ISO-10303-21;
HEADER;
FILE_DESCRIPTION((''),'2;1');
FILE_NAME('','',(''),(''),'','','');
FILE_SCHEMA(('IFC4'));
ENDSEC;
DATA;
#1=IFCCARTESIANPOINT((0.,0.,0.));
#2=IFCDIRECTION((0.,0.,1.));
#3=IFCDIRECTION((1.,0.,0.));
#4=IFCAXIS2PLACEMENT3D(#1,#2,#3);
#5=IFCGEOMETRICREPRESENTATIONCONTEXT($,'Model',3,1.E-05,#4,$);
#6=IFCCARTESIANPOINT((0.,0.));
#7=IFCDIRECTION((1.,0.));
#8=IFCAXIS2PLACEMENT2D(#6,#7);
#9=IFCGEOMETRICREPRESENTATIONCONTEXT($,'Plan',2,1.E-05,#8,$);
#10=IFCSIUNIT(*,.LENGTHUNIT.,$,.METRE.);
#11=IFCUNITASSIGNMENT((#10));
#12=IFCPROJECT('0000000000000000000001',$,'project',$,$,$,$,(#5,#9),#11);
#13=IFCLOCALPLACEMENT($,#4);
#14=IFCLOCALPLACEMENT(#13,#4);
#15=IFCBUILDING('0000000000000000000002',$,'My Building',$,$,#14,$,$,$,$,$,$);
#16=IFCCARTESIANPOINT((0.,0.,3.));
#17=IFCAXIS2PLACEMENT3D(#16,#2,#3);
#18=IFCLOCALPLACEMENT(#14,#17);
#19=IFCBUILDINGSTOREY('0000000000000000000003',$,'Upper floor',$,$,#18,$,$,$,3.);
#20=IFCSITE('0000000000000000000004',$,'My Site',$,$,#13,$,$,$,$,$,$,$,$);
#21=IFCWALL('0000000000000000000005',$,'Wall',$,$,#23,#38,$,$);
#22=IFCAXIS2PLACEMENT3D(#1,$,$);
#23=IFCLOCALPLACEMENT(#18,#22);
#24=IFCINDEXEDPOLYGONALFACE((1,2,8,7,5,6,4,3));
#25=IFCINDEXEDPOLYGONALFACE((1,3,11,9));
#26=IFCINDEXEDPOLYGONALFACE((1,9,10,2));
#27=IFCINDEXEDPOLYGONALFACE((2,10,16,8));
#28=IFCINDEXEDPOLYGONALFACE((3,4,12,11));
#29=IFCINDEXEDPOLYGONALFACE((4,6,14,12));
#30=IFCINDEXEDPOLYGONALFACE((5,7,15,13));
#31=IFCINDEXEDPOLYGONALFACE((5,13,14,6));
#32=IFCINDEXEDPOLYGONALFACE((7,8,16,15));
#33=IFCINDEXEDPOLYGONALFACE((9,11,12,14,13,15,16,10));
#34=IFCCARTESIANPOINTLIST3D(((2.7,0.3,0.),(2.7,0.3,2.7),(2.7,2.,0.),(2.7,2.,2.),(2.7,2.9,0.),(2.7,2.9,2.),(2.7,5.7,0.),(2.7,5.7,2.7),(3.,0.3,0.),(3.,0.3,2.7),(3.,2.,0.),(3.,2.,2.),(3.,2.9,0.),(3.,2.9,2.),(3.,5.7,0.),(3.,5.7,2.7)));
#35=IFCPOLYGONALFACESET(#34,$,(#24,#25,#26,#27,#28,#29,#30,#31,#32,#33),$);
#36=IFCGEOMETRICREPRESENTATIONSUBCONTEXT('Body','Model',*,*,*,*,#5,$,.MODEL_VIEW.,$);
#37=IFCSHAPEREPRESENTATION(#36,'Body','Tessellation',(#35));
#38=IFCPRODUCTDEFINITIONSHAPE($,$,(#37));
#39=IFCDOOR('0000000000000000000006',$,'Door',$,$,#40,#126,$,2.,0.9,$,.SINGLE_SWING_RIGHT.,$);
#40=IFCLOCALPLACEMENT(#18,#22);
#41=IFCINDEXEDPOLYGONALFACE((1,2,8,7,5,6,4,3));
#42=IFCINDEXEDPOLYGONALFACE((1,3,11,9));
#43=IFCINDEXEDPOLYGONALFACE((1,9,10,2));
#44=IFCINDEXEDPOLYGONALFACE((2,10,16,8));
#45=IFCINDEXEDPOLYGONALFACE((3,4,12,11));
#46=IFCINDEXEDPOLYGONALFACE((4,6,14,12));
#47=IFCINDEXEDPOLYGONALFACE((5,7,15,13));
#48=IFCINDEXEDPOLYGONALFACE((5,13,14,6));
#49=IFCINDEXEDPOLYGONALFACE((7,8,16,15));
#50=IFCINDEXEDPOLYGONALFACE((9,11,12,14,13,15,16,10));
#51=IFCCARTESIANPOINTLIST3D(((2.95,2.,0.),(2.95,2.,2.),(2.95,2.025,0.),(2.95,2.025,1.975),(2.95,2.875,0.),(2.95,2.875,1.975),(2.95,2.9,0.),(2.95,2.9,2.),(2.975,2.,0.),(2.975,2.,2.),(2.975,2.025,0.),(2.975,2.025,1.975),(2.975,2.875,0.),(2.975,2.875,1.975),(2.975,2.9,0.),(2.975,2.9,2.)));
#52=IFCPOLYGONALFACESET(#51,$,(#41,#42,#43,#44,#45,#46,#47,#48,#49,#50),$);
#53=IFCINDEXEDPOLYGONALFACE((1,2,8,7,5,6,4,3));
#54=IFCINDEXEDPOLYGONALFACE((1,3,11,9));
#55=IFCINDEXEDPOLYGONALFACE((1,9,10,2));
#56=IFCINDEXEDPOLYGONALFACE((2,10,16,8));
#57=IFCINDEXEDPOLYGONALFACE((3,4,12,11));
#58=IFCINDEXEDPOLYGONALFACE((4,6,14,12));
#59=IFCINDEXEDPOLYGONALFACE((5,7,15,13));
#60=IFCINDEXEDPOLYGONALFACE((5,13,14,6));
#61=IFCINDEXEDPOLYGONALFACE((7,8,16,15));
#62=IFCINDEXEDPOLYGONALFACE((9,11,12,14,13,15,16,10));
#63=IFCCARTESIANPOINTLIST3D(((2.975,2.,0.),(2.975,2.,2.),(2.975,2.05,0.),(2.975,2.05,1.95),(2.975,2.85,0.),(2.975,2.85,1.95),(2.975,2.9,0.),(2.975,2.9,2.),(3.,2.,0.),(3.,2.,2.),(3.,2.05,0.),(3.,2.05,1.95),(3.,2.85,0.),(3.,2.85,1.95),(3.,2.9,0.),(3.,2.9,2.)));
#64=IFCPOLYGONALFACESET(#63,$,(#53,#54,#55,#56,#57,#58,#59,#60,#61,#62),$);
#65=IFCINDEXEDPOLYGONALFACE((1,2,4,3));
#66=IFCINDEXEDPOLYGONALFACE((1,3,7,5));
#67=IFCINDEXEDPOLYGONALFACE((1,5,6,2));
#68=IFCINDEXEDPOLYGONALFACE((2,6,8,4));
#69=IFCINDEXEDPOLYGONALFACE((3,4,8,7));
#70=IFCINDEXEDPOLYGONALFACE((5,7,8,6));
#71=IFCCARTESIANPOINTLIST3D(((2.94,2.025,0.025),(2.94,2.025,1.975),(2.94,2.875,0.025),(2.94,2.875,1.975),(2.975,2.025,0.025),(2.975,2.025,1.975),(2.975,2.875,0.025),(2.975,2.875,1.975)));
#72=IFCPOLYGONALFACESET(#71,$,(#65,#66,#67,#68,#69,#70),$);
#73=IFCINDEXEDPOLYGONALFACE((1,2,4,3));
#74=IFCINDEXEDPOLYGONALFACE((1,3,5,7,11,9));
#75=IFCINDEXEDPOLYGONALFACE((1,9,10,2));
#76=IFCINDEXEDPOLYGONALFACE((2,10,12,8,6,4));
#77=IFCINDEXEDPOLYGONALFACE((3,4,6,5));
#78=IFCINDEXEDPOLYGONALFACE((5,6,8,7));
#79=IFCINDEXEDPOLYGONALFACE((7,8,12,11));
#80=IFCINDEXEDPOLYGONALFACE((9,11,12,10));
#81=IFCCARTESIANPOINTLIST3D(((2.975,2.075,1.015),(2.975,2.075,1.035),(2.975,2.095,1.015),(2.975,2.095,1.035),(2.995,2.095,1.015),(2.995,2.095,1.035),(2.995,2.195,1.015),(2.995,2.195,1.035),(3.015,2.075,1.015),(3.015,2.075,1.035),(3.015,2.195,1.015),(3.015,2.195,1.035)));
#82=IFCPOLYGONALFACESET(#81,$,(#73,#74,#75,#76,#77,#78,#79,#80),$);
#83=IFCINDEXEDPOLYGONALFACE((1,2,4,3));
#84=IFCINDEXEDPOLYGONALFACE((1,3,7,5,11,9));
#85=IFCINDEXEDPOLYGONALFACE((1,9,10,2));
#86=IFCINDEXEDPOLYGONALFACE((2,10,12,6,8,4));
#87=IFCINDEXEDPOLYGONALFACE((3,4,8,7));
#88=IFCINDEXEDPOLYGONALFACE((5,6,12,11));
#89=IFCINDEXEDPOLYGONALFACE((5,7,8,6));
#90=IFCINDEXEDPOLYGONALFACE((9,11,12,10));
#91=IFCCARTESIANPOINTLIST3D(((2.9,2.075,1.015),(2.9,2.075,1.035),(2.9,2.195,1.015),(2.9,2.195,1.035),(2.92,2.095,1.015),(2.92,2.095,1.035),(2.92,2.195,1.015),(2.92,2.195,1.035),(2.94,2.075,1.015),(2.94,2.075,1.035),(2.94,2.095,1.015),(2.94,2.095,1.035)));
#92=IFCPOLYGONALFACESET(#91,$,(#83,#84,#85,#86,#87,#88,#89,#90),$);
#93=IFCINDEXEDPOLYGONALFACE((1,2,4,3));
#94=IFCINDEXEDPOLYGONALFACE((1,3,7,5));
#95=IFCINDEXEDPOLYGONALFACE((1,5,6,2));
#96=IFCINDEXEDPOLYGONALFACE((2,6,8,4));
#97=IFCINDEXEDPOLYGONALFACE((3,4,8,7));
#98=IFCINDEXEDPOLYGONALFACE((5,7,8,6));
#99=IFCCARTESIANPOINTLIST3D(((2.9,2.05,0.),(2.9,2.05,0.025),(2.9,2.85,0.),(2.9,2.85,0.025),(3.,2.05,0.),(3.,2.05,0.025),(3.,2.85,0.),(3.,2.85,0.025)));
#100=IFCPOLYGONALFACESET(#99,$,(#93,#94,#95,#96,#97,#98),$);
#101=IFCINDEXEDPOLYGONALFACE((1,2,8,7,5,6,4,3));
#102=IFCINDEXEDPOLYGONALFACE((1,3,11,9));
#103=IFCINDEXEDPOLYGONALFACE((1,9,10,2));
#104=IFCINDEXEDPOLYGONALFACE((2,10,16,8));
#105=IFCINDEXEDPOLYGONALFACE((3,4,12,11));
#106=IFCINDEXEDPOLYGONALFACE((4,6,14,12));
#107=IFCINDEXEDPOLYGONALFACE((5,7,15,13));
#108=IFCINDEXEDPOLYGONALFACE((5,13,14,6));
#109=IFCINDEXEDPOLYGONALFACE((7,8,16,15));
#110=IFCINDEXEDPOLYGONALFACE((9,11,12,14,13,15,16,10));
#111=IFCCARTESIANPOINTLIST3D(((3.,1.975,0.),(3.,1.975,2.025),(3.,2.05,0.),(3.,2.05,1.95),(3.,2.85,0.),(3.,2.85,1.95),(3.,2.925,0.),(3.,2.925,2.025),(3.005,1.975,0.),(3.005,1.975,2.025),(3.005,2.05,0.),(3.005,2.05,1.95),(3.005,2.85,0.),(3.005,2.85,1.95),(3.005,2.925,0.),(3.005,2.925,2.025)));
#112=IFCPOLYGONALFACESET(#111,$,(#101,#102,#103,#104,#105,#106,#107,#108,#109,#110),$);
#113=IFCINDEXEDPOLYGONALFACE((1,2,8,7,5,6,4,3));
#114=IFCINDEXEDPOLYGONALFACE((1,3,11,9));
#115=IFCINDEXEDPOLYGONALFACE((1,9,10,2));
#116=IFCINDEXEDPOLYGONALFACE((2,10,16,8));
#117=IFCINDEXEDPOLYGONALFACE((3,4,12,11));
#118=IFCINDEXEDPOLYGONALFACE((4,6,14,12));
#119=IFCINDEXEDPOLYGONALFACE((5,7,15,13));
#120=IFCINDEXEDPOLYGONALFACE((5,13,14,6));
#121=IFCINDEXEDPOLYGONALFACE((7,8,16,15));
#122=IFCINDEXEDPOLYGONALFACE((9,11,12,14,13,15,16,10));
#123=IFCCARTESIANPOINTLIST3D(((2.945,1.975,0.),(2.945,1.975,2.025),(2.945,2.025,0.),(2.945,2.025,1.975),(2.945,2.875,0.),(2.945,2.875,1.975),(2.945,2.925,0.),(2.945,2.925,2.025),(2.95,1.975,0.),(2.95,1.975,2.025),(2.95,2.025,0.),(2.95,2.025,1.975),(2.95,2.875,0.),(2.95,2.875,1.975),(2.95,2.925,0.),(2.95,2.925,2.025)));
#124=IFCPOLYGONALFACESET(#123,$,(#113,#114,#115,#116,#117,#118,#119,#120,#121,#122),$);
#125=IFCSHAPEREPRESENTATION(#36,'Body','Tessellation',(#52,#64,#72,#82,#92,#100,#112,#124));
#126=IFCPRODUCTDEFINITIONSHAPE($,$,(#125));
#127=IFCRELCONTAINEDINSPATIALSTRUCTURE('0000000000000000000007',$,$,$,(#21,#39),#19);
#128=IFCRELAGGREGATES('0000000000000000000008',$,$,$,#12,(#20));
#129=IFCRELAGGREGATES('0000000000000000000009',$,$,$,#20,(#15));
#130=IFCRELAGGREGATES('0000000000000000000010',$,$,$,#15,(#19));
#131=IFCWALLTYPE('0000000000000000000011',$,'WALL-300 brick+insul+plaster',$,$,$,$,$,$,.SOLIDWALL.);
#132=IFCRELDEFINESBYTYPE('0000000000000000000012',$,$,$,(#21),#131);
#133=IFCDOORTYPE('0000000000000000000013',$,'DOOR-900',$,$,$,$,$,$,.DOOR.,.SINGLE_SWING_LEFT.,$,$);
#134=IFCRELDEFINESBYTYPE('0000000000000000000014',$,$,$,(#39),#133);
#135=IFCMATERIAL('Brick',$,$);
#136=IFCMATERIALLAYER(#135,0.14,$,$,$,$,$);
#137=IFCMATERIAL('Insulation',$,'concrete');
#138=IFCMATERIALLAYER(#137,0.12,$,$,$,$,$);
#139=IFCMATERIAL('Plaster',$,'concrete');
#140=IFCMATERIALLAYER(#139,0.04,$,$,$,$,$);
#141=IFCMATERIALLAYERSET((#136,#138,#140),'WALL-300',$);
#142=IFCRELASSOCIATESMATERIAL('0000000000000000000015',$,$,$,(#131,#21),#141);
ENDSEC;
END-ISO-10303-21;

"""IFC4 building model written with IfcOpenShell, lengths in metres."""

from ifc_helpers import new_model, entity, si_unit, frame, origin_with_axes, origin_2d_with_axis, place, context, subcontext, project, spatial, line, indexed_curve, outline, extrude, shape, source, transform, mapped, material, layer, layer_set, layer_usage, type_object, type_shapes, element, fill, save


model = new_model("IFC4")

# Units and contexts
model_context = context("Model", 3, precision=1e-05, world=origin_with_axes())
plan_context = context("Plan", 2, precision=1e-05, world=origin_2d_with_axis())
body_context_1 = subcontext(model_context, "Body", "Model", "MODEL_VIEW")
body_context_2 = subcontext(plan_context, "Body", "Plan", "PLAN_VIEW")
ifc_project = project(units=[si_unit("LENGTHUNIT", "METRE")], contexts=[model_context, plan_context])

# Site, building, storey
site_placement = place(None, origin_with_axes())
site = spatial("IfcSite", under=ifc_project, at=site_placement, Name="My Site")
building_placement = place(site_placement, origin_with_axes())
building = spatial("IfcBuilding", under=site, at=building_placement, Name="My Building")
storey_placement = place(building_placement, frame((0.0, 0.0, 3.0), z_axis=(0.0, 0.0, 1.0), x_axis=(1.0, 0.0, 0.0)))
storey = spatial("IfcBuildingStorey", under=building, at=storey_placement, Name="Upper floor", Elevation=3.0)

# Shared definitions
ifc_material_1 = material(Name="Brick")

# Shared definitions
ifc_layer_1 = layer(ifc_material_1, 0.14)
ifc_material_2 = material(Name="Insulation", Category="concrete")
ifc_layer_2 = layer(ifc_material_2, 0.12)
ifc_material_3 = material(Name="Plaster", Category="concrete")
ifc_layer_3 = layer(ifc_material_3, 0.04)
ifc_layer_set_1 = layer_set([ifc_layer_1, ifc_layer_2, ifc_layer_3], Name="WALL-300")
wall_type = type_object("IfcWallType", Name="WALL-300 brick+insul+plaster", PredefinedType="SOLIDWALL", material=ifc_layer_set_1)

# Wall, opening, door
ifc_layer_usage_1 = layer_usage(ifc_layer_set_1, "AXIS2", "POSITIVE", 0.0)
wall_1_placement = place(storey_placement, frame((3.0, 0.0, 0.0), z_axis=(0.0, 0.0, 1.0), x_axis=(0.0, 1.0, 0.0)))
wall_1 = element("IfcWall", 1, at=wall_1_placement, inside=storey, type_object=wall_type, material=ifc_layer_usage_1, Name="Wall", context=body_context_1, shape_type="SweptSolid", body=[
    extrude(outline(indexed_curve([(0.3, 0.0), (0.3, 0.3), (5.7, 0.3), (5.7, 0.0)], segments=[line(1, 2, 3, 4, 1)])), origin_with_axes(), (0.0, 0.0, 1.0), 2.7),
])
shared_shape_1 = source(origin_with_axes(), body_context_1, "Body", "SweptSolid", [
    extrude(outline(indexed_curve([(0.0, 0.0), (0.9, 0.0), (0.9, 2.0), (0.0, 2.0)], segments=[line(1, 2, 3, 4, 1)])), frame((0.0, -0.6, 0.0), z_axis=(0.0, -1.0, 0.0), x_axis=(1.0, 0.0, 0.0)), (0.0, 0.0, -1.0), 1.2),
])
opening_1_placement = place(wall_1_placement, frame((2.0, 0.0, 0.0), z_axis=(0.0, 0.0, 1.0), x_axis=(1.0, 0.0, 0.0)))
opening_1 = element("IfcOpeningElement", 2, at=opening_1_placement, cuts=wall_1, PredefinedType="OPENING", context=body_context_1, shape_type="MappedRepresentation", body=[
    mapped(shared_shape_1, transform((0.0, 0.0, 0.0), x_axis=(1.0, 0.0, 0.0), y_axis=(0.0, 1.0, 0.0), z_axis=(0.0, 0.0, 1.0), scale=1.0)),
])
door_type = type_object("IfcDoorType", Name="DOOR-900", OperationType="SINGLE_SWING_LEFT", PredefinedType="DOOR")
shared_shape_2 = source(origin_with_axes(), body_context_1, "Body", "SweptSolid", [
    extrude(outline(indexed_curve([(0.0, 0.0), (0.0, 2.0), (0.9, 2.0), (0.9, 0.0), (0.875, 0.0), (0.875, 1.975), (0.025, 1.975), (0.025, 0.0)], segments=[line(1, 2, 3, 4, 5, 6, 7, 8, 1)])), frame((0.0, 0.025, 0.0), z_axis=(0.0, -1.0, 0.0), x_axis=(1.0, 0.0, 0.0)), (0.0, 0.0, -1.0), 0.025),
    extrude(outline(indexed_curve([(0.0, 0.0), (0.0, 2.0), (0.9, 2.0), (0.9, 0.0), (0.85, 0.0), (0.85, 1.95), (0.05, 1.95), (0.05, 0.0)], segments=[line(1, 2, 3, 4, 5, 6, 7, 8, 1)])), frame((0.0, 0.0, 0.0), z_axis=(0.0, -1.0, 0.0), x_axis=(1.0, 0.0, 0.0)), (0.0, 0.0, -1.0), 0.025),
    extrude(outline(indexed_curve([(0.0, 0.0), (0.85, 0.0), (0.85, 0.035), (0.0, 0.035)], segments=[line(1, 2, 3, 4, 1)])), frame((0.025, 0.025, 0.025), z_axis=(0.0, 0.0, 1.0), x_axis=(1.0, 0.0, 0.0)), (0.0, 0.0, 1.0), 1.95),
    extrude(outline(indexed_curve([(0.0, 0.0), (0.0, -0.04), (0.12, -0.04), (0.12, -0.02), (0.02, -0.02), (0.02, 0.0)], segments=[line(1, 2, 3, 4, 5, 6, 1)])), frame((0.075, 0.025, 1.015), z_axis=(0.0, 0.0, 1.0), x_axis=(1.0, 0.0, 0.0)), (0.0, 0.0, 1.0), 0.02),
    extrude(outline(indexed_curve([(0.0, 0.0), (0.0, 0.04), (0.12, 0.04), (0.12, 0.02), (0.02, 0.02), (0.02, 0.0)], segments=[line(1, 2, 3, 4, 5, 6, 1)])), frame((0.075, 0.06, 1.015), z_axis=(0.0, 0.0, 1.0), x_axis=(1.0, 0.0, 0.0)), (0.0, 0.0, 1.0), 0.02),
    extrude(outline(indexed_curve([(0.0, 0.0), (0.8, 0.0), (0.8, 0.1), (0.0, 0.1)], segments=[line(1, 2, 3, 4, 1)])), frame((0.05, 0.0, 0.0), z_axis=(0.0, 0.0, 1.0), x_axis=(1.0, 0.0, 0.0)), (0.0, 0.0, 1.0), 0.025),
    extrude(outline(indexed_curve([(0.0, 0.0), (0.0, 2.025), (0.95, 2.025), (0.95, 0.0), (0.875, 0.0), (0.875, 1.95), (0.075, 1.95), (0.075, 0.0)], segments=[line(1, 2, 3, 4, 5, 6, 7, 8, 1)])), frame((-0.025, -0.005, 0.0), z_axis=(0.0, -1.0, 0.0), x_axis=(1.0, 0.0, 0.0)), (0.0, 0.0, -1.0), 0.005),
    extrude(outline(indexed_curve([(0.0, 0.0), (0.0, 2.025), (0.95, 2.025), (0.95, 0.0), (0.9, 0.0), (0.9, 1.975), (0.05, 1.975), (0.05, 0.0)], segments=[line(1, 2, 3, 4, 5, 6, 7, 8, 1)])), frame((-0.025, 0.05, 0.0), z_axis=(0.0, -1.0, 0.0), x_axis=(1.0, 0.0, 0.0)), (0.0, 0.0, -1.0), 0.005),
])
shared_shape_3 = source(origin_with_axes(), body_context_2, "Body", "Curve2D", [
    entity("IfcIndexedPolyCurve", entity("IfcCartesianPointList2D", [[0.0, 0.0], [0.0, 0.05], [0.025, 0.05], [0.025, 0.025], [0.05, 0.025], [0.05, 0.0]]), [entity("IfcLineIndex", [1, 2, 3, 4, 5, 6, 1])]),
    entity("IfcIndexedPolyCurve", entity("IfcCartesianPointList2D", [[0.9, 0.0], [0.9, 0.05], [0.875, 0.05], [0.875, 0.025], [0.85, 0.025], [0.85, 0.0]]), [entity("IfcLineIndex", [1, 2, 3, 4, 5, 6, 1])]),
    entity("IfcTrimmedCurve", entity("IfcEllipse", entity("IfcAxis2Placement2D", entity("IfcCartesianPoint", [0.84, 0.05]), entity("IfcDirection", [1.0, 0.0])), 0.815, 0.85), [entity("IfcCartesianPoint", [0.84, 0.9])], [entity("IfcCartesianPoint", [0.025, 0.05])], True, "CARTESIAN"),
    entity("IfcIndexedPolyCurve", entity("IfcCartesianPointList2D", [[0.875, 0.05], [0.84, 0.05], [0.84, 0.9], [0.875, 0.9]]), [entity("IfcLineIndex", [1, 2, 3, 4, 1])]),
])
type_shapes(door_type, [shared_shape_2, shared_shape_3])
door_placement = place(opening_1_placement, frame((0.0, 0.0, 0.0), z_axis=(0.0, 0.0, 1.0), x_axis=(1.0, 0.0, 0.0)))
door = element("IfcDoor", 3, at=door_placement, inside=storey, type_object=door_type, Name="Door", OperationType="SINGLE_SWING_RIGHT", OverallHeight=2.0, OverallWidth=0.9, shapes=[
    shape(body_context_1, "Body", "MappedRepresentation", [mapped(shared_shape_2, transform((0.0, 0.0, 0.0), x_axis=(1.0, 0.0, 0.0), y_axis=(0.0, 1.0, 0.0), z_axis=(0.0, 0.0, 1.0), scale=1.0))]),
    shape(body_context_2, "Body", "MappedRepresentation", [mapped(shared_shape_3, transform((0.0, 0.0, 0.0), x_axis=(1.0, 0.0, 0.0), y_axis=(0.0, 1.0, 0.0), z_axis=(0.0, 0.0, 1.0), scale=1.0))]),
])
fill(opening_1, door)

save(model, "model.ifc")
